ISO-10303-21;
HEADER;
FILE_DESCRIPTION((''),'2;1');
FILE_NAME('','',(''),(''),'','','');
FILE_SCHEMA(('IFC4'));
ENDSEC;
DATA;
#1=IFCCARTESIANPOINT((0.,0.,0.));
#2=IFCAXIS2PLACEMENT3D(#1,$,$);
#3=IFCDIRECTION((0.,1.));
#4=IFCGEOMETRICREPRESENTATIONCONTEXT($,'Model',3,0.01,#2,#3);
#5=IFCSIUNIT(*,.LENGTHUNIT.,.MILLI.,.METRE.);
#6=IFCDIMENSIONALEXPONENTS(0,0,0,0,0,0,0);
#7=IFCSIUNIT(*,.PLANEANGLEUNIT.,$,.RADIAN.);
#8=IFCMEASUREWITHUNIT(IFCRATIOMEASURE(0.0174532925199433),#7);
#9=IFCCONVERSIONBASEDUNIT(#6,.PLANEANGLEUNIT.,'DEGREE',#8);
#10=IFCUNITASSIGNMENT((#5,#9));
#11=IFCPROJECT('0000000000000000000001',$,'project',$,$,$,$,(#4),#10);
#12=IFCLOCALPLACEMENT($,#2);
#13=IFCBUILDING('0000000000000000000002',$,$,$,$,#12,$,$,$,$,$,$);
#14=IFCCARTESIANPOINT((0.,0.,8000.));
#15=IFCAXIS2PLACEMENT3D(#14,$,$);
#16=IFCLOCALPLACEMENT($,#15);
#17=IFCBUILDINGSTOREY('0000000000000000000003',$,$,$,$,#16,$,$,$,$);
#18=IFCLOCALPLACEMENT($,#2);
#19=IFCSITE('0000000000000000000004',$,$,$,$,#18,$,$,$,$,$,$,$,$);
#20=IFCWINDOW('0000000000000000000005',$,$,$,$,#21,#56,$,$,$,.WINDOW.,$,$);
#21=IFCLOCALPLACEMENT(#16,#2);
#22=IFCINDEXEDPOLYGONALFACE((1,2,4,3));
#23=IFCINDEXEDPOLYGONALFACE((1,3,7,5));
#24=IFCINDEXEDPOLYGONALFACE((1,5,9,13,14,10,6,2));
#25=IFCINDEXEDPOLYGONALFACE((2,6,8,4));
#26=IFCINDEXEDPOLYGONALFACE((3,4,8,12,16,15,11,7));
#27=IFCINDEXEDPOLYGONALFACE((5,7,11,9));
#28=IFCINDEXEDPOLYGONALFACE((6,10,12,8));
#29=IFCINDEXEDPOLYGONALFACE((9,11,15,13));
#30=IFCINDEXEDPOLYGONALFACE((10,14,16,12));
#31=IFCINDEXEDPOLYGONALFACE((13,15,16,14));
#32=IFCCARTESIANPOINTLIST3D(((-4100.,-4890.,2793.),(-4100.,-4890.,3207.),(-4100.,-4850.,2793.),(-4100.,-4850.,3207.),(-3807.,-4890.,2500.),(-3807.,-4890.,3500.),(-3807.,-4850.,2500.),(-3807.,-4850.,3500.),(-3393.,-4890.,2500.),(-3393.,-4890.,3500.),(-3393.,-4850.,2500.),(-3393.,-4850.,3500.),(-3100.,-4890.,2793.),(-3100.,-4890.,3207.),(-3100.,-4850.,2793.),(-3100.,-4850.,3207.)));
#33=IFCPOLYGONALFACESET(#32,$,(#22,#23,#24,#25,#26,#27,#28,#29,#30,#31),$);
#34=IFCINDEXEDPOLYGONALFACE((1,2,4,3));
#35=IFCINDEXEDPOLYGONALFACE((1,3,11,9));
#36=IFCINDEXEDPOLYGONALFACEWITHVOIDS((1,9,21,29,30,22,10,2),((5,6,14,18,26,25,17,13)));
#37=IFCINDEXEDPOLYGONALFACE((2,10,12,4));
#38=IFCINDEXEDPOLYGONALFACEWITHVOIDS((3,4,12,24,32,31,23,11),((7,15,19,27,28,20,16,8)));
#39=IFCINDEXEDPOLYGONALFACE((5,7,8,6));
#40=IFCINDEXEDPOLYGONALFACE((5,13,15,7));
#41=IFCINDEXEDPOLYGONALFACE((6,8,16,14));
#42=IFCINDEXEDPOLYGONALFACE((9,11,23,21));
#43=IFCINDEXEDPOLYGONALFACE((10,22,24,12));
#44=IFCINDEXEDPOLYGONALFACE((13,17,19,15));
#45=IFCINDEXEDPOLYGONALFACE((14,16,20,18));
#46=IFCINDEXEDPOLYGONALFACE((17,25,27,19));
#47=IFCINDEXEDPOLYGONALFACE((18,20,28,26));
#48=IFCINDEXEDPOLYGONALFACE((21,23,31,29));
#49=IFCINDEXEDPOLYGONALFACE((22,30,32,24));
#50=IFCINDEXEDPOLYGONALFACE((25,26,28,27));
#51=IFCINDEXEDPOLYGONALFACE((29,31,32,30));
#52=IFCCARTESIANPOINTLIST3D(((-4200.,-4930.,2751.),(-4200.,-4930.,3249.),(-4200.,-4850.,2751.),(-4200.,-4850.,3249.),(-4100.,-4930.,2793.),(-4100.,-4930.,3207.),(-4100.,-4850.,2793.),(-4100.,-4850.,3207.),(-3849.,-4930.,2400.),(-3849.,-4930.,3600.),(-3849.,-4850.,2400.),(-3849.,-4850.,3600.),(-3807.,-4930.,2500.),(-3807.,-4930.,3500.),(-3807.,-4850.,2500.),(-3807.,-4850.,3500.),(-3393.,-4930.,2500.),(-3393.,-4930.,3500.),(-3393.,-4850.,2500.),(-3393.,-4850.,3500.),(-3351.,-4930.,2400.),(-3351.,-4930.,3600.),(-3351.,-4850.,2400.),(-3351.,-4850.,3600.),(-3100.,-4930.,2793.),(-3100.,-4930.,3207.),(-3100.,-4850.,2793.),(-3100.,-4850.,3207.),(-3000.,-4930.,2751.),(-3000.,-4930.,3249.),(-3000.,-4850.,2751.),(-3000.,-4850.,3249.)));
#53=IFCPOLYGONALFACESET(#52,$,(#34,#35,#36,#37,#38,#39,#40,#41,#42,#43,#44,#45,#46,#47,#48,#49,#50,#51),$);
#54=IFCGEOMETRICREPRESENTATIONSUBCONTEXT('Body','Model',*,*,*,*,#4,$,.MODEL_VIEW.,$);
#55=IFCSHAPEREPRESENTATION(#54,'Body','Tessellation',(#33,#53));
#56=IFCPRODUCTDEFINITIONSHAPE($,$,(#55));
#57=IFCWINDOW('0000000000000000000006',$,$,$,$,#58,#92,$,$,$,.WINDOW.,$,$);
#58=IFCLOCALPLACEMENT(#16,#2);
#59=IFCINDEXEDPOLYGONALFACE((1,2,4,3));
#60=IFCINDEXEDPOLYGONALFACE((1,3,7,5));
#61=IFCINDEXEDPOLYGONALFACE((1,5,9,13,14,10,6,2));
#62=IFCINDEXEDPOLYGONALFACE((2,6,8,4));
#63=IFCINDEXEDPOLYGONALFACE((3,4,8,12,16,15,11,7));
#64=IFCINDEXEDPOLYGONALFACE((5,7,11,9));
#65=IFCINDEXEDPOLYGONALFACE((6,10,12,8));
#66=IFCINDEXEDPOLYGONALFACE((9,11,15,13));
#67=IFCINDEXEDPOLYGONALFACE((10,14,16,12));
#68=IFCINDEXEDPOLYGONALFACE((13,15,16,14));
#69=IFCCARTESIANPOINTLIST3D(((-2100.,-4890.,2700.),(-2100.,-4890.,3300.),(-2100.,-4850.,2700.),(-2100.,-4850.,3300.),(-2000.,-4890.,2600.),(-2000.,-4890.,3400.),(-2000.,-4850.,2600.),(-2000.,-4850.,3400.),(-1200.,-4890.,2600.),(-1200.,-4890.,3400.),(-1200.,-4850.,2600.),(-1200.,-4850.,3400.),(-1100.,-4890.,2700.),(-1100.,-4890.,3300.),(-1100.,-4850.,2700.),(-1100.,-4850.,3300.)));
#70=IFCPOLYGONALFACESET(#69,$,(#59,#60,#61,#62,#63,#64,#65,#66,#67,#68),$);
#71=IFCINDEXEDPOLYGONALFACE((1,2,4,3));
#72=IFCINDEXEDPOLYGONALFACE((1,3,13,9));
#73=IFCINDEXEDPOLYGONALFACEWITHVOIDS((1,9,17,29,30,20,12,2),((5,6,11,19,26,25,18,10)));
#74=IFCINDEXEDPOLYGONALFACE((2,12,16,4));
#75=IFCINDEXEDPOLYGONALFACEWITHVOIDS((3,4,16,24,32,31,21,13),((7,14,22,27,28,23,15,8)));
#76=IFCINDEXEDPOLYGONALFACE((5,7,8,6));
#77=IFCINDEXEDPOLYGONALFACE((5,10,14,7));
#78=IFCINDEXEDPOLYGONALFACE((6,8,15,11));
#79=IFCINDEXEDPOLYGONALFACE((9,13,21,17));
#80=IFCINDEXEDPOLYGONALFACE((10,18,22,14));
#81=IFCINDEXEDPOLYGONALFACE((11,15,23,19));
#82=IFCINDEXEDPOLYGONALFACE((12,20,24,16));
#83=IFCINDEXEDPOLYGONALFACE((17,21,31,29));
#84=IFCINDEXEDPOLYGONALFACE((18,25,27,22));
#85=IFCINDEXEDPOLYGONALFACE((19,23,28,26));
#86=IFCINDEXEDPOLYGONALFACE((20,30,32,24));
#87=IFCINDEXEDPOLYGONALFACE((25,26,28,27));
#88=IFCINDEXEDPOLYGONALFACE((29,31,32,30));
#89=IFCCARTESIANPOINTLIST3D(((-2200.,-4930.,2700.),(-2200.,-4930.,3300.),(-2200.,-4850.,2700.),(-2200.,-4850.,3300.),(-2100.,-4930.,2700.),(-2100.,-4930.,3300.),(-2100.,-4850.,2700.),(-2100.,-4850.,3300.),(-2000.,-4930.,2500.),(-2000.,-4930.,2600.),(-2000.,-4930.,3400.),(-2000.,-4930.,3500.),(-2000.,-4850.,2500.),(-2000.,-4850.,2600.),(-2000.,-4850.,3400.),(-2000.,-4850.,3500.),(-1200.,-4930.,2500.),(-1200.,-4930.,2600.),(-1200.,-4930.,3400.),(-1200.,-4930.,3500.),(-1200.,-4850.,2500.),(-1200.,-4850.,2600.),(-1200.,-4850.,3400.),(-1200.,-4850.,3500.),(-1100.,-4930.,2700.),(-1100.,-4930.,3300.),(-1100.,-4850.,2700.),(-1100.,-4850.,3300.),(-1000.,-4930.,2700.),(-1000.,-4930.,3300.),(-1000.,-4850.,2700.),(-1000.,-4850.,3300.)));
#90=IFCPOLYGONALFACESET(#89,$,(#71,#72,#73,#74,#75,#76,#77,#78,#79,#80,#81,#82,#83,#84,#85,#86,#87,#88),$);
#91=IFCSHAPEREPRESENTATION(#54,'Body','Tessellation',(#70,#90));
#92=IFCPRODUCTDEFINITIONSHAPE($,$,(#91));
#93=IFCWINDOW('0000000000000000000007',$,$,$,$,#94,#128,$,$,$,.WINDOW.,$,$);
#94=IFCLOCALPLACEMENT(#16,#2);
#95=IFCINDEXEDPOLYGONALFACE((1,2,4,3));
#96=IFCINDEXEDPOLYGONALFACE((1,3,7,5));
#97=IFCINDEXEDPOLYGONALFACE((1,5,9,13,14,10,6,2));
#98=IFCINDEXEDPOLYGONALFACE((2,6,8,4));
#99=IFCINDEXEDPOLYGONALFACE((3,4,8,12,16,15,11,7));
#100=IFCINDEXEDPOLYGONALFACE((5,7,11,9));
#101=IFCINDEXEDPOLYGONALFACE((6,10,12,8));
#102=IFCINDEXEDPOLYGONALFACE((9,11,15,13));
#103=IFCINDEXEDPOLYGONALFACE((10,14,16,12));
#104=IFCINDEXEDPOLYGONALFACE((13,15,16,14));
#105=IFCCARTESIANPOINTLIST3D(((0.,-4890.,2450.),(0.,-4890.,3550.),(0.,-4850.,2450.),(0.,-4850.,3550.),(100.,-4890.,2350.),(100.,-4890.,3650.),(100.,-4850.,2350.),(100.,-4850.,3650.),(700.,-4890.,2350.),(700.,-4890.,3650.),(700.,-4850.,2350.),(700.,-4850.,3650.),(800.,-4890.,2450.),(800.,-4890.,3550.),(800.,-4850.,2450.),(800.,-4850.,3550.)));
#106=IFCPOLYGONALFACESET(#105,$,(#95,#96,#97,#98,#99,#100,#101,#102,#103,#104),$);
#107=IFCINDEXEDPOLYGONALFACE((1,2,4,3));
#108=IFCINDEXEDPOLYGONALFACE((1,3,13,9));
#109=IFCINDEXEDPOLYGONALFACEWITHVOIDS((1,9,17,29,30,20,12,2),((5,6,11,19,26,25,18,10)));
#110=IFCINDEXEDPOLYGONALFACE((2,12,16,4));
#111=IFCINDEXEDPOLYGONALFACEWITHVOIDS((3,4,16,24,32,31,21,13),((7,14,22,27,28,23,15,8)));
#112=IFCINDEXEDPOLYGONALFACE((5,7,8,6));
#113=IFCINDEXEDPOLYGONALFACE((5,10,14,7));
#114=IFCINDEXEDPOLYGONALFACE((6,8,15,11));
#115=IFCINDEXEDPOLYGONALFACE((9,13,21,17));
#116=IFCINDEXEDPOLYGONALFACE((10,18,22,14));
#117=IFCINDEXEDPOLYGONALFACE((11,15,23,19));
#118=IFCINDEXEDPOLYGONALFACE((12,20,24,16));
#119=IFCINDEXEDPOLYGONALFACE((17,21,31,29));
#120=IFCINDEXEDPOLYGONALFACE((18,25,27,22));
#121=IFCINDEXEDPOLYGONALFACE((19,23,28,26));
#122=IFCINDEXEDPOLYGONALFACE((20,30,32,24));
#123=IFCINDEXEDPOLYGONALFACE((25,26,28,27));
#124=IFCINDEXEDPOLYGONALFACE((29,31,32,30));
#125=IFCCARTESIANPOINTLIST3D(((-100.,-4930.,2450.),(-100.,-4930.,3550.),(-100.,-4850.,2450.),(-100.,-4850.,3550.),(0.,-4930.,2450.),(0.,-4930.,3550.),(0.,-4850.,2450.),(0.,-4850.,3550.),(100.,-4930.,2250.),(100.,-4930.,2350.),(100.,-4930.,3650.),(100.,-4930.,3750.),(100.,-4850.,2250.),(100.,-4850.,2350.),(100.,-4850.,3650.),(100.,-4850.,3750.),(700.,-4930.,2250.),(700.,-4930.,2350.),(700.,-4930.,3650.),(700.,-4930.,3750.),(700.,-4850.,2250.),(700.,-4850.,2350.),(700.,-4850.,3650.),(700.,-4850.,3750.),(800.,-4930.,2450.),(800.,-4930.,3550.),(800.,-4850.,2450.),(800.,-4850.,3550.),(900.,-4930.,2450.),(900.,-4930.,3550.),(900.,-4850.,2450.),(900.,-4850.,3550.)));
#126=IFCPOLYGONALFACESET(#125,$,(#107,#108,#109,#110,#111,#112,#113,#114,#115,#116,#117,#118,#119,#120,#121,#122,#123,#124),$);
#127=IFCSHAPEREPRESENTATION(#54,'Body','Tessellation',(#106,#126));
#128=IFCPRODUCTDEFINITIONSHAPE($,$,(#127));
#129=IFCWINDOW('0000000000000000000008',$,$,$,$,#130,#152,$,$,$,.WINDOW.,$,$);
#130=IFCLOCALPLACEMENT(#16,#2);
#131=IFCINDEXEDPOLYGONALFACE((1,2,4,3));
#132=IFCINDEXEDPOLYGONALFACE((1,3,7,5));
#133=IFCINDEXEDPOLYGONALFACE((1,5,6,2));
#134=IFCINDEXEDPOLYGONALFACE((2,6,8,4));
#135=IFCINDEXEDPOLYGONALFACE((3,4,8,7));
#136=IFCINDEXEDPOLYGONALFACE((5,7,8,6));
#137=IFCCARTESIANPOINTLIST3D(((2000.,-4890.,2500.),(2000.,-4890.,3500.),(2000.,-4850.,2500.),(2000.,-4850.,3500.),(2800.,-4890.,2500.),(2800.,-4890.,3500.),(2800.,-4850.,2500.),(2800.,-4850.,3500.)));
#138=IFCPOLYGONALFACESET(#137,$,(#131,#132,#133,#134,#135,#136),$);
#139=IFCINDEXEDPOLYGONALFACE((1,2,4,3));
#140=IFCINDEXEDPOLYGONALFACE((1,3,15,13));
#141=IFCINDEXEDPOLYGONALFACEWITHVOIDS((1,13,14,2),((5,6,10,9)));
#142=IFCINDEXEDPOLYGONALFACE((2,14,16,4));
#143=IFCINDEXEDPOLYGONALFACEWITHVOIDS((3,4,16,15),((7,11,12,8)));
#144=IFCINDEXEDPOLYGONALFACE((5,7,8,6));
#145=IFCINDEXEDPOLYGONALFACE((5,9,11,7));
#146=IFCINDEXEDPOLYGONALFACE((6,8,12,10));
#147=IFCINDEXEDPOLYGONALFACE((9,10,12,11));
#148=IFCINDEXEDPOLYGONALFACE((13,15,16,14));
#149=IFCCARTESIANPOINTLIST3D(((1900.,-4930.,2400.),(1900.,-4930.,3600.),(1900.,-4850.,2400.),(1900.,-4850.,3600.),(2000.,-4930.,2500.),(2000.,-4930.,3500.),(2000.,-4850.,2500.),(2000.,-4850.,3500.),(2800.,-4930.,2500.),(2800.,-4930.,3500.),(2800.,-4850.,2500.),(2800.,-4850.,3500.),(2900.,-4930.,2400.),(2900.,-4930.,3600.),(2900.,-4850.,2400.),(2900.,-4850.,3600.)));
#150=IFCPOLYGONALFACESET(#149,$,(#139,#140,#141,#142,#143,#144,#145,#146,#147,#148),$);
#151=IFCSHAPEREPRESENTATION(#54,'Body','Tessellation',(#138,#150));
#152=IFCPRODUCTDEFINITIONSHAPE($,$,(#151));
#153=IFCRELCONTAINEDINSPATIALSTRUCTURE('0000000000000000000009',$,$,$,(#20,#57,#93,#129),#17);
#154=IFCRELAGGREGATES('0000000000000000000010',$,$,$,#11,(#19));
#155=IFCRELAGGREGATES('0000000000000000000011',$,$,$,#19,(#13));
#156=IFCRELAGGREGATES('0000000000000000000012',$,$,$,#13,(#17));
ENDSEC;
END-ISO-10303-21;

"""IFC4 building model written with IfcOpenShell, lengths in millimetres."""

from ifc_helpers import new_model, entity, si_unit, converted_unit, direction, frame, origin, place, context, subcontext, project, spatial, element, save


model = new_model("IFC4")

# Units and contexts
model_context = context("Model", 3, precision=0.01, world=origin(), true_north=direction((0.0, 1.0)))
body_context = subcontext(model_context, "Body", "Model", "MODEL_VIEW")
ifc_project = project(units=[si_unit("LENGTHUNIT", "METRE", prefix="MILLI"), converted_unit("PLANEANGLEUNIT", "DEGREE", entity("IfcRatioMeasure", 0.0174532925199433), si_unit("PLANEANGLEUNIT", "RADIAN"), dimensions=[0, 0, 0, 0, 0, 0, 0])], contexts=[model_context])

# Site, building, storey
site_placement = place(None, origin())
site = spatial("IfcSite", under=ifc_project, at=site_placement)
building_placement = place(None, origin())
building = spatial("IfcBuilding", under=site, at=building_placement)
storey_placement = place(None, frame((0.0, 0.0, 8000.0)))
storey = spatial("IfcBuildingStorey", under=building, at=storey_placement)

# Shared definitions
cartesian_point_1 = entity("IfcCartesianPoint", [-500.0, -207.0])
shared_polyline_1 = entity("IfcPolyline", [cartesian_point_1, entity("IfcCartesianPoint", [-500.0, 207.0]), entity("IfcCartesianPoint", [-207.0, 500.0]), entity("IfcCartesianPoint", [207.0, 500.0]), entity("IfcCartesianPoint", [500.0, 207.0]), entity("IfcCartesianPoint", [500.0, -207.0]), entity("IfcCartesianPoint", [207.0, -500.0]), entity("IfcCartesianPoint", [-207.0, -500.0]), cartesian_point_1])
cartesian_point_2 = entity("IfcCartesianPoint", [-500.0, -300.0])
shared_polyline_2 = entity("IfcPolyline", [cartesian_point_2, entity("IfcCartesianPoint", [-500.0, 300.0]), entity("IfcCartesianPoint", [-400.0, 400.0]), entity("IfcCartesianPoint", [400.0, 400.0]), entity("IfcCartesianPoint", [500.0, 300.0]), entity("IfcCartesianPoint", [500.0, -300.0]), entity("IfcCartesianPoint", [400.0, -400.0]), entity("IfcCartesianPoint", [-400.0, -400.0]), cartesian_point_2])
cartesian_point_3 = entity("IfcCartesianPoint", [-400.0, -550.0])
shared_polyline_3 = entity("IfcPolyline", [cartesian_point_3, entity("IfcCartesianPoint", [-400.0, 550.0]), entity("IfcCartesianPoint", [-300.0, 650.0]), entity("IfcCartesianPoint", [300.0, 650.0]), entity("IfcCartesianPoint", [400.0, 550.0]), entity("IfcCartesianPoint", [400.0, -550.0]), entity("IfcCartesianPoint", [300.0, -650.0]), entity("IfcCartesianPoint", [-300.0, -650.0]), cartesian_point_3])
cartesian_point_4 = entity("IfcCartesianPoint", [-400.0, -500.0])
shared_polyline_4 = entity("IfcPolyline", [cartesian_point_4, entity("IfcCartesianPoint", [-400.0, 500.0]), entity("IfcCartesianPoint", [-400.0, 500.0]), entity("IfcCartesianPoint", [400.0, 500.0]), entity("IfcCartesianPoint", [400.0, 500.0]), entity("IfcCartesianPoint", [400.0, -500.0]), entity("IfcCartesianPoint", [400.0, -500.0]), entity("IfcCartesianPoint", [-400.0, -500.0]), cartesian_point_4])

# Shared definitions
wall_1_placement = place(storey_placement, frame((-100.0, -4900.0, 0.0), z_axis=(0.0, 0.0, 1.0), x_axis=(1.0, 0.0, 0.0)))
window_1_placement = place(wall_1_placement, frame((-3500.0, 50.0, 3000.0)))
window_2_placement = place(wall_1_placement, frame((-1500.0, 50.0, 3000.0)))
window_3_placement = place(wall_1_placement, frame((500.0, 50.0, 3000.0)))
window_4_placement = place(wall_1_placement, frame((2500.0, 50.0, 3000.0)))

# Windows
cartesian_point_5 = entity("IfcCartesianPoint", [-600.0, -249.0])
element("IfcWindow", 1, at=window_1_placement, inside=storey, PredefinedType="WINDOW", context=body_context, shape_type="SweptSolid", body=[
    entity("IfcExtrudedAreaSolid", entity("IfcArbitraryClosedProfileDef", "AREA", None, shared_polyline_1), entity("IfcAxis2Placement3D", entity("IfcCartesianPoint", [0.0, 0.0, 0.0]), entity("IfcDirection", [0.0, -1.0, 0.0]), entity("IfcDirection", [1.0, 0.0, 0.0])), entity("IfcDirection", [0.0, 0.0, 1.0]), 40.0),
    entity("IfcExtrudedAreaSolid", entity("IfcArbitraryProfileDefWithVoids", "AREA", None, entity("IfcPolyline", [cartesian_point_5, entity("IfcCartesianPoint", [-600.0, 249.0]), entity("IfcCartesianPoint", [-249.0, 600.0]), entity("IfcCartesianPoint", [249.0, 600.0]), entity("IfcCartesianPoint", [600.0, 249.0]), entity("IfcCartesianPoint", [600.0, -249.0]), entity("IfcCartesianPoint", [249.0, -600.0]), entity("IfcCartesianPoint", [-249.0, -600.0]), cartesian_point_5]), [shared_polyline_1]), entity("IfcAxis2Placement3D", entity("IfcCartesianPoint", [0.0, 0.0, 0.0]), entity("IfcDirection", [0.0, -1.0, 0.0]), entity("IfcDirection", [1.0, 0.0, 0.0])), entity("IfcDirection", [0.0, 0.0, 1.0]), 80.0),
])
cartesian_point_6 = entity("IfcCartesianPoint", [-600.0, -300.0])
element("IfcWindow", 2, at=window_2_placement, inside=storey, PredefinedType="WINDOW", context=body_context, shape_type="SweptSolid", body=[
    entity("IfcExtrudedAreaSolid", entity("IfcArbitraryClosedProfileDef", "AREA", None, shared_polyline_2), entity("IfcAxis2Placement3D", entity("IfcCartesianPoint", [0.0, 0.0, 0.0]), entity("IfcDirection", [0.0, -1.0, 0.0]), entity("IfcDirection", [1.0, 0.0, 0.0])), entity("IfcDirection", [0.0, 0.0, 1.0]), 40.0),
    entity("IfcExtrudedAreaSolid", entity("IfcArbitraryProfileDefWithVoids", "AREA", None, entity("IfcPolyline", [cartesian_point_6, entity("IfcCartesianPoint", [-600.0, 300.0]), entity("IfcCartesianPoint", [-400.0, 500.0]), entity("IfcCartesianPoint", [400.0, 500.0]), entity("IfcCartesianPoint", [600.0, 300.0]), entity("IfcCartesianPoint", [600.0, -300.0]), entity("IfcCartesianPoint", [400.0, -500.0]), entity("IfcCartesianPoint", [-400.0, -500.0]), cartesian_point_6]), [shared_polyline_2]), entity("IfcAxis2Placement3D", entity("IfcCartesianPoint", [0.0, 0.0, 0.0]), entity("IfcDirection", [0.0, -1.0, 0.0]), entity("IfcDirection", [1.0, 0.0, 0.0])), entity("IfcDirection", [0.0, 0.0, 1.0]), 80.0),
])
cartesian_point_7 = entity("IfcCartesianPoint", [-500.0, -550.0])
element("IfcWindow", 3, at=window_3_placement, inside=storey, PredefinedType="WINDOW", context=body_context, shape_type="SweptSolid", body=[
    entity("IfcExtrudedAreaSolid", entity("IfcArbitraryClosedProfileDef", "AREA", None, shared_polyline_3), entity("IfcAxis2Placement3D", entity("IfcCartesianPoint", [0.0, 0.0, 0.0]), entity("IfcDirection", [0.0, -1.0, 0.0]), entity("IfcDirection", [1.0, 0.0, 0.0])), entity("IfcDirection", [0.0, 0.0, 1.0]), 40.0),
    entity("IfcExtrudedAreaSolid", entity("IfcArbitraryProfileDefWithVoids", "AREA", None, entity("IfcPolyline", [cartesian_point_7, entity("IfcCartesianPoint", [-500.0, 550.0]), entity("IfcCartesianPoint", [-300.0, 750.0]), entity("IfcCartesianPoint", [300.0, 750.0]), entity("IfcCartesianPoint", [500.0, 550.0]), entity("IfcCartesianPoint", [500.0, -550.0]), entity("IfcCartesianPoint", [300.0, -750.0]), entity("IfcCartesianPoint", [-300.0, -750.0]), cartesian_point_7]), [shared_polyline_3]), entity("IfcAxis2Placement3D", entity("IfcCartesianPoint", [0.0, 0.0, 0.0]), entity("IfcDirection", [0.0, -1.0, 0.0]), entity("IfcDirection", [1.0, 0.0, 0.0])), entity("IfcDirection", [0.0, 0.0, 1.0]), 80.0),
])
cartesian_point_8 = entity("IfcCartesianPoint", [-500.0, -600.0])
element("IfcWindow", 4, at=window_4_placement, inside=storey, PredefinedType="WINDOW", context=body_context, shape_type="SweptSolid", body=[
    entity("IfcExtrudedAreaSolid", entity("IfcArbitraryClosedProfileDef", "AREA", None, shared_polyline_4), entity("IfcAxis2Placement3D", entity("IfcCartesianPoint", [0.0, 0.0, 0.0]), entity("IfcDirection", [0.0, -1.0, 0.0]), entity("IfcDirection", [1.0, 0.0, 0.0])), entity("IfcDirection", [0.0, 0.0, 1.0]), 40.0),
    entity("IfcExtrudedAreaSolid", entity("IfcArbitraryProfileDefWithVoids", "AREA", None, entity("IfcPolyline", [cartesian_point_8, entity("IfcCartesianPoint", [-500.0, 600.0]), entity("IfcCartesianPoint", [-500.0, 600.0]), entity("IfcCartesianPoint", [500.0, 600.0]), entity("IfcCartesianPoint", [500.0, 600.0]), entity("IfcCartesianPoint", [500.0, -600.0]), entity("IfcCartesianPoint", [500.0, -600.0]), entity("IfcCartesianPoint", [-500.0, -600.0]), cartesian_point_8]), [shared_polyline_4]), entity("IfcAxis2Placement3D", entity("IfcCartesianPoint", [0.0, 0.0, 0.0]), entity("IfcDirection", [0.0, -1.0, 0.0]), entity("IfcDirection", [1.0, 0.0, 0.0])), entity("IfcDirection", [0.0, 0.0, 1.0]), 80.0),
])

save(model, "model.ifc")
